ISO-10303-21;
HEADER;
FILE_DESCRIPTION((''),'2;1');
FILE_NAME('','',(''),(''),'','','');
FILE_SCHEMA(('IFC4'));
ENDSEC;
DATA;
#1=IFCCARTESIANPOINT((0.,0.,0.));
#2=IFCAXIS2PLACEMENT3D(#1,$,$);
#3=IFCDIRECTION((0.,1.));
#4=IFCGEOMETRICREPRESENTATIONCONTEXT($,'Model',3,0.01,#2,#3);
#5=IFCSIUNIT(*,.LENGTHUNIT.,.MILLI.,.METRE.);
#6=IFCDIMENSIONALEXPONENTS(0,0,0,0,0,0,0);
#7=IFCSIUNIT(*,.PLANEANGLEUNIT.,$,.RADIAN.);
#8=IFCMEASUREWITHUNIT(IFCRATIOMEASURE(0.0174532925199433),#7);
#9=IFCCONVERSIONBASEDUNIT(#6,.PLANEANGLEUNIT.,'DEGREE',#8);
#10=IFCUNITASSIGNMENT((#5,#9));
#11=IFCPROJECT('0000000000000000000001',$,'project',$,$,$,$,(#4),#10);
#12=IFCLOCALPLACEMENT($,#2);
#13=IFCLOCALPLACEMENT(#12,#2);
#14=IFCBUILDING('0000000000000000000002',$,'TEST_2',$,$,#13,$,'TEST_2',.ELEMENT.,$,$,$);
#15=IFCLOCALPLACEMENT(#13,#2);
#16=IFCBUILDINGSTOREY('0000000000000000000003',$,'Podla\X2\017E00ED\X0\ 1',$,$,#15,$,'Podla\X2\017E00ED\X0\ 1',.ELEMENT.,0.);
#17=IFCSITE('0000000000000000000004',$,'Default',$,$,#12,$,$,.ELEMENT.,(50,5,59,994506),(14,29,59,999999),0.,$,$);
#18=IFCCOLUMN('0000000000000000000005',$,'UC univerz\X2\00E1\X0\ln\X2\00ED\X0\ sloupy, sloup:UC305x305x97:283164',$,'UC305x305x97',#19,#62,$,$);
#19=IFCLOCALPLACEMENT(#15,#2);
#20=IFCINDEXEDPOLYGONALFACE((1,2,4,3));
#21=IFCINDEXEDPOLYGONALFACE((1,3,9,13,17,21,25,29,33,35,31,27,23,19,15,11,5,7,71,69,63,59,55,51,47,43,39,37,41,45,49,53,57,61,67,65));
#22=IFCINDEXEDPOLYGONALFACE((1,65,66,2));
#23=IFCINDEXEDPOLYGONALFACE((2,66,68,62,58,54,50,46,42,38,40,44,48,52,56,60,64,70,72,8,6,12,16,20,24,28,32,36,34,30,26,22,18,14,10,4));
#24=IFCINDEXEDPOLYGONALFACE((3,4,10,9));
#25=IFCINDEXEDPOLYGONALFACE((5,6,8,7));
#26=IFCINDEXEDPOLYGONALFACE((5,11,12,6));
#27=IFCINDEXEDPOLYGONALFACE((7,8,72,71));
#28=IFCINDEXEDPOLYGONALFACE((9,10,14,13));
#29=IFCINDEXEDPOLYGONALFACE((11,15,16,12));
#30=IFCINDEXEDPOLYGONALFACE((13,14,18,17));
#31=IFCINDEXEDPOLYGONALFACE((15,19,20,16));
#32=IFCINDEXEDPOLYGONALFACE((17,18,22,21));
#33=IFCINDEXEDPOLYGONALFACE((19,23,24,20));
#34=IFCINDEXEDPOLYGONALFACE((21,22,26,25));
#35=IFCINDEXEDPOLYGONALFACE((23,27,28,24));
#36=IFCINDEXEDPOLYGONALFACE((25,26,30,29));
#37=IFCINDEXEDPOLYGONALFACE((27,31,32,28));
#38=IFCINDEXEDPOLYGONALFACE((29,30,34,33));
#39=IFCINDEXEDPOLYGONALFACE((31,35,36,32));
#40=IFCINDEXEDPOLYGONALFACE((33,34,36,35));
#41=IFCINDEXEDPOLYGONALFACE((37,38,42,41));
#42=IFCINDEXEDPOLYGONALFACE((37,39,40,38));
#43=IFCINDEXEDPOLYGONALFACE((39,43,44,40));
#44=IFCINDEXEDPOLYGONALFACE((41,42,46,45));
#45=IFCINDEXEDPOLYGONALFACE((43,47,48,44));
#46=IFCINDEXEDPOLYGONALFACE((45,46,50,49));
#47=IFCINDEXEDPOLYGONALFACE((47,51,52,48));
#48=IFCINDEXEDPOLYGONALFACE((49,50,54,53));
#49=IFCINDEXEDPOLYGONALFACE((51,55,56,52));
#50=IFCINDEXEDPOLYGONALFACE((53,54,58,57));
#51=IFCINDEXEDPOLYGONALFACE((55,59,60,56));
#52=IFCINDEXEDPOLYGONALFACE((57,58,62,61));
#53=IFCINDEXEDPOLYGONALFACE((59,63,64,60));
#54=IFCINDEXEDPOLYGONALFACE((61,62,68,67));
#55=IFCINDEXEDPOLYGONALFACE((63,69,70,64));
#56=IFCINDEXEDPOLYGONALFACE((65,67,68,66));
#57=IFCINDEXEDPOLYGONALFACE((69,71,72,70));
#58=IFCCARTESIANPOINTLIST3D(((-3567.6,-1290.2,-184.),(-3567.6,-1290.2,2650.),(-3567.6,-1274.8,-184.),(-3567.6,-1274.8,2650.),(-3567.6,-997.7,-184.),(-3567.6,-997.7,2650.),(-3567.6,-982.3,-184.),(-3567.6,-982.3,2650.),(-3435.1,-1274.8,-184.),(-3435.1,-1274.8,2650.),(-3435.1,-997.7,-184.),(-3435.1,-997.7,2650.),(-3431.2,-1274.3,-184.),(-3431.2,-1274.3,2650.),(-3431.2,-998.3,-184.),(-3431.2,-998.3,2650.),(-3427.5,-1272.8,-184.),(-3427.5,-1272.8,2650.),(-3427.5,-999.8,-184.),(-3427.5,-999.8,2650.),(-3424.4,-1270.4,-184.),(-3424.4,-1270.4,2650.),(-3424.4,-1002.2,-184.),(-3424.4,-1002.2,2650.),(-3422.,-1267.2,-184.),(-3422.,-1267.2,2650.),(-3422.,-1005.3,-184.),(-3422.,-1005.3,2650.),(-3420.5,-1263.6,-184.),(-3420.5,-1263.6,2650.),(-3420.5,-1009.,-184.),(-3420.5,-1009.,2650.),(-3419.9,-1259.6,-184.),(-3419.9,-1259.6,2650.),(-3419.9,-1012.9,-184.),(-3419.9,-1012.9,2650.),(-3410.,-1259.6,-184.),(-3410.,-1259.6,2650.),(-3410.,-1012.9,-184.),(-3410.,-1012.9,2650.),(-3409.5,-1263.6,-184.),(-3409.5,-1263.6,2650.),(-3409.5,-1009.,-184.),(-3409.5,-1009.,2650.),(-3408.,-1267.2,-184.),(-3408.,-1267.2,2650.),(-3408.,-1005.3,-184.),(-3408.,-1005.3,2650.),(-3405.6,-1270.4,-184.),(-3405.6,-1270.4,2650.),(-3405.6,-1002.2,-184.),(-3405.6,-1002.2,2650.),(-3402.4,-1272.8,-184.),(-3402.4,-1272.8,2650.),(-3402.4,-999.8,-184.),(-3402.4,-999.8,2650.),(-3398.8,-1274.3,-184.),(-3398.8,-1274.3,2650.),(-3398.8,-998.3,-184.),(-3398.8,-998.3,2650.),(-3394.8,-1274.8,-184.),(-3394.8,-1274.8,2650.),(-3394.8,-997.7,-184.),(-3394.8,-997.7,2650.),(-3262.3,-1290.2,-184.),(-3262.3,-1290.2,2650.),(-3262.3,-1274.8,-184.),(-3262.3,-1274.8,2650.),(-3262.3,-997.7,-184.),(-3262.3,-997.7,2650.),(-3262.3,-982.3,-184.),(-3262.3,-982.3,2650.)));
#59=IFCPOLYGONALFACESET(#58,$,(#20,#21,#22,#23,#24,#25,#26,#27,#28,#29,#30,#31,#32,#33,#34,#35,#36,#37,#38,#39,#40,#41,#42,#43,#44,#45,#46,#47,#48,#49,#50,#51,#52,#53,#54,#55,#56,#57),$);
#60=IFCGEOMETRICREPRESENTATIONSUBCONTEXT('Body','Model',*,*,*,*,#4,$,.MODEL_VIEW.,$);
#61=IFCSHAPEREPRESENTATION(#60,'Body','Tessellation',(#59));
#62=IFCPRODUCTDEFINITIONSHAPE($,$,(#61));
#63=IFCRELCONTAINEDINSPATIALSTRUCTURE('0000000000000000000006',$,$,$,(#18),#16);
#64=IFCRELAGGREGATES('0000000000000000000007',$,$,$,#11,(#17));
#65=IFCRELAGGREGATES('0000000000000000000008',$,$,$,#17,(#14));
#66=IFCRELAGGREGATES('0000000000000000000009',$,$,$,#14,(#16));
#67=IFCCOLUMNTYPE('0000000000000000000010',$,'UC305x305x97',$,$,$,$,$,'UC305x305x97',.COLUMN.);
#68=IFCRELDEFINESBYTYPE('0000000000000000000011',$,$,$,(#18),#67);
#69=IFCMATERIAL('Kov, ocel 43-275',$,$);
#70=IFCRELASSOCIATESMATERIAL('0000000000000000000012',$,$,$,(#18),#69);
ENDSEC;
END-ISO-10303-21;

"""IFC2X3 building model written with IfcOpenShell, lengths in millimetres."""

from ifc_helpers import new_model, entity, si_unit, converted_unit, direction, frame, origin, origin_2d_with_axis, place, context, subcontext, project, spatial, i_section, extrude, source, transform, mapped, material, type_object, type_shapes, element, save


model = new_model("IFC2X3")

# Units and contexts
model_context = context("Model", 3, precision=0.01, world=origin(), true_north=direction((0.0, 1.0)))
body_context = subcontext(model_context, "Body", "Model", "MODEL_VIEW")
ifc_project = project(units=[si_unit("LENGTHUNIT", "METRE", prefix="MILLI"), converted_unit("PLANEANGLEUNIT", "DEGREE", entity("IfcRatioMeasure", 0.0174532925199433), si_unit("PLANEANGLEUNIT", "RADIAN"), dimensions=[0, 0, 0, 0, 0, 0, 0])], contexts=[model_context])

# Site, building, storey
site_placement = place(None, origin())
site = spatial("IfcSite", under=ifc_project, at=site_placement, Name="Default", CompositionType="ELEMENT", RefLatitude=(50, 5, 59, 994506), RefLongitude=(14, 29, 59, 999999), RefElevation=0.0)
building_placement = place(site_placement, origin())
building = spatial("IfcBuilding", under=site, at=building_placement, Name="TEST_2", LongName="TEST_2", CompositionType="ELEMENT")
storey_placement = place(building_placement, origin())
storey = spatial("IfcBuildingStorey", under=building, at=storey_placement, Name="Podlaží 1", LongName="Podlaží 1", CompositionType="ELEMENT", Elevation=0.0)

# Column
ifc_material_1 = material(Name="Kov, ocel 43-275")
column_type = type_object("IfcColumnType", Name="UC305x305x97", ElementType="UC305x305x97", PredefinedType="COLUMN")
shared_shape_1 = source(origin(), body_context, "Body", "SweptSolid", [
    extrude(i_section(OverallWidth=305.3, OverallDepth=307.9, WebThickness=9.9, FlangeThickness=15.4, FilletRadius=15.2, at=origin_2d_with_axis()), frame((0.0, 0.0, -184.0), z_axis=(0.0, 0.0, 1.0), x_axis=(-1.0, 0.0, 0.0)), (0.0, 0.0, 1.0), 2834.0),
])
type_shapes(column_type, [shared_shape_1])
column_placement = place(storey_placement, frame((-3415.0, -1136.3, 0.0)))
element("IfcColumn", 1, at=column_placement, inside=storey, type_object=column_type, material=ifc_material_1, Name="UC univerzální sloupy, sloup:UC305x305x97:283164", ObjectType="UC305x305x97", context=body_context, shape_type="MappedRepresentation", body=[
    mapped(shared_shape_1, transform((0.0, 0.0, 0.0), scale=1.0)),
])

save(model, "model.ifc")
